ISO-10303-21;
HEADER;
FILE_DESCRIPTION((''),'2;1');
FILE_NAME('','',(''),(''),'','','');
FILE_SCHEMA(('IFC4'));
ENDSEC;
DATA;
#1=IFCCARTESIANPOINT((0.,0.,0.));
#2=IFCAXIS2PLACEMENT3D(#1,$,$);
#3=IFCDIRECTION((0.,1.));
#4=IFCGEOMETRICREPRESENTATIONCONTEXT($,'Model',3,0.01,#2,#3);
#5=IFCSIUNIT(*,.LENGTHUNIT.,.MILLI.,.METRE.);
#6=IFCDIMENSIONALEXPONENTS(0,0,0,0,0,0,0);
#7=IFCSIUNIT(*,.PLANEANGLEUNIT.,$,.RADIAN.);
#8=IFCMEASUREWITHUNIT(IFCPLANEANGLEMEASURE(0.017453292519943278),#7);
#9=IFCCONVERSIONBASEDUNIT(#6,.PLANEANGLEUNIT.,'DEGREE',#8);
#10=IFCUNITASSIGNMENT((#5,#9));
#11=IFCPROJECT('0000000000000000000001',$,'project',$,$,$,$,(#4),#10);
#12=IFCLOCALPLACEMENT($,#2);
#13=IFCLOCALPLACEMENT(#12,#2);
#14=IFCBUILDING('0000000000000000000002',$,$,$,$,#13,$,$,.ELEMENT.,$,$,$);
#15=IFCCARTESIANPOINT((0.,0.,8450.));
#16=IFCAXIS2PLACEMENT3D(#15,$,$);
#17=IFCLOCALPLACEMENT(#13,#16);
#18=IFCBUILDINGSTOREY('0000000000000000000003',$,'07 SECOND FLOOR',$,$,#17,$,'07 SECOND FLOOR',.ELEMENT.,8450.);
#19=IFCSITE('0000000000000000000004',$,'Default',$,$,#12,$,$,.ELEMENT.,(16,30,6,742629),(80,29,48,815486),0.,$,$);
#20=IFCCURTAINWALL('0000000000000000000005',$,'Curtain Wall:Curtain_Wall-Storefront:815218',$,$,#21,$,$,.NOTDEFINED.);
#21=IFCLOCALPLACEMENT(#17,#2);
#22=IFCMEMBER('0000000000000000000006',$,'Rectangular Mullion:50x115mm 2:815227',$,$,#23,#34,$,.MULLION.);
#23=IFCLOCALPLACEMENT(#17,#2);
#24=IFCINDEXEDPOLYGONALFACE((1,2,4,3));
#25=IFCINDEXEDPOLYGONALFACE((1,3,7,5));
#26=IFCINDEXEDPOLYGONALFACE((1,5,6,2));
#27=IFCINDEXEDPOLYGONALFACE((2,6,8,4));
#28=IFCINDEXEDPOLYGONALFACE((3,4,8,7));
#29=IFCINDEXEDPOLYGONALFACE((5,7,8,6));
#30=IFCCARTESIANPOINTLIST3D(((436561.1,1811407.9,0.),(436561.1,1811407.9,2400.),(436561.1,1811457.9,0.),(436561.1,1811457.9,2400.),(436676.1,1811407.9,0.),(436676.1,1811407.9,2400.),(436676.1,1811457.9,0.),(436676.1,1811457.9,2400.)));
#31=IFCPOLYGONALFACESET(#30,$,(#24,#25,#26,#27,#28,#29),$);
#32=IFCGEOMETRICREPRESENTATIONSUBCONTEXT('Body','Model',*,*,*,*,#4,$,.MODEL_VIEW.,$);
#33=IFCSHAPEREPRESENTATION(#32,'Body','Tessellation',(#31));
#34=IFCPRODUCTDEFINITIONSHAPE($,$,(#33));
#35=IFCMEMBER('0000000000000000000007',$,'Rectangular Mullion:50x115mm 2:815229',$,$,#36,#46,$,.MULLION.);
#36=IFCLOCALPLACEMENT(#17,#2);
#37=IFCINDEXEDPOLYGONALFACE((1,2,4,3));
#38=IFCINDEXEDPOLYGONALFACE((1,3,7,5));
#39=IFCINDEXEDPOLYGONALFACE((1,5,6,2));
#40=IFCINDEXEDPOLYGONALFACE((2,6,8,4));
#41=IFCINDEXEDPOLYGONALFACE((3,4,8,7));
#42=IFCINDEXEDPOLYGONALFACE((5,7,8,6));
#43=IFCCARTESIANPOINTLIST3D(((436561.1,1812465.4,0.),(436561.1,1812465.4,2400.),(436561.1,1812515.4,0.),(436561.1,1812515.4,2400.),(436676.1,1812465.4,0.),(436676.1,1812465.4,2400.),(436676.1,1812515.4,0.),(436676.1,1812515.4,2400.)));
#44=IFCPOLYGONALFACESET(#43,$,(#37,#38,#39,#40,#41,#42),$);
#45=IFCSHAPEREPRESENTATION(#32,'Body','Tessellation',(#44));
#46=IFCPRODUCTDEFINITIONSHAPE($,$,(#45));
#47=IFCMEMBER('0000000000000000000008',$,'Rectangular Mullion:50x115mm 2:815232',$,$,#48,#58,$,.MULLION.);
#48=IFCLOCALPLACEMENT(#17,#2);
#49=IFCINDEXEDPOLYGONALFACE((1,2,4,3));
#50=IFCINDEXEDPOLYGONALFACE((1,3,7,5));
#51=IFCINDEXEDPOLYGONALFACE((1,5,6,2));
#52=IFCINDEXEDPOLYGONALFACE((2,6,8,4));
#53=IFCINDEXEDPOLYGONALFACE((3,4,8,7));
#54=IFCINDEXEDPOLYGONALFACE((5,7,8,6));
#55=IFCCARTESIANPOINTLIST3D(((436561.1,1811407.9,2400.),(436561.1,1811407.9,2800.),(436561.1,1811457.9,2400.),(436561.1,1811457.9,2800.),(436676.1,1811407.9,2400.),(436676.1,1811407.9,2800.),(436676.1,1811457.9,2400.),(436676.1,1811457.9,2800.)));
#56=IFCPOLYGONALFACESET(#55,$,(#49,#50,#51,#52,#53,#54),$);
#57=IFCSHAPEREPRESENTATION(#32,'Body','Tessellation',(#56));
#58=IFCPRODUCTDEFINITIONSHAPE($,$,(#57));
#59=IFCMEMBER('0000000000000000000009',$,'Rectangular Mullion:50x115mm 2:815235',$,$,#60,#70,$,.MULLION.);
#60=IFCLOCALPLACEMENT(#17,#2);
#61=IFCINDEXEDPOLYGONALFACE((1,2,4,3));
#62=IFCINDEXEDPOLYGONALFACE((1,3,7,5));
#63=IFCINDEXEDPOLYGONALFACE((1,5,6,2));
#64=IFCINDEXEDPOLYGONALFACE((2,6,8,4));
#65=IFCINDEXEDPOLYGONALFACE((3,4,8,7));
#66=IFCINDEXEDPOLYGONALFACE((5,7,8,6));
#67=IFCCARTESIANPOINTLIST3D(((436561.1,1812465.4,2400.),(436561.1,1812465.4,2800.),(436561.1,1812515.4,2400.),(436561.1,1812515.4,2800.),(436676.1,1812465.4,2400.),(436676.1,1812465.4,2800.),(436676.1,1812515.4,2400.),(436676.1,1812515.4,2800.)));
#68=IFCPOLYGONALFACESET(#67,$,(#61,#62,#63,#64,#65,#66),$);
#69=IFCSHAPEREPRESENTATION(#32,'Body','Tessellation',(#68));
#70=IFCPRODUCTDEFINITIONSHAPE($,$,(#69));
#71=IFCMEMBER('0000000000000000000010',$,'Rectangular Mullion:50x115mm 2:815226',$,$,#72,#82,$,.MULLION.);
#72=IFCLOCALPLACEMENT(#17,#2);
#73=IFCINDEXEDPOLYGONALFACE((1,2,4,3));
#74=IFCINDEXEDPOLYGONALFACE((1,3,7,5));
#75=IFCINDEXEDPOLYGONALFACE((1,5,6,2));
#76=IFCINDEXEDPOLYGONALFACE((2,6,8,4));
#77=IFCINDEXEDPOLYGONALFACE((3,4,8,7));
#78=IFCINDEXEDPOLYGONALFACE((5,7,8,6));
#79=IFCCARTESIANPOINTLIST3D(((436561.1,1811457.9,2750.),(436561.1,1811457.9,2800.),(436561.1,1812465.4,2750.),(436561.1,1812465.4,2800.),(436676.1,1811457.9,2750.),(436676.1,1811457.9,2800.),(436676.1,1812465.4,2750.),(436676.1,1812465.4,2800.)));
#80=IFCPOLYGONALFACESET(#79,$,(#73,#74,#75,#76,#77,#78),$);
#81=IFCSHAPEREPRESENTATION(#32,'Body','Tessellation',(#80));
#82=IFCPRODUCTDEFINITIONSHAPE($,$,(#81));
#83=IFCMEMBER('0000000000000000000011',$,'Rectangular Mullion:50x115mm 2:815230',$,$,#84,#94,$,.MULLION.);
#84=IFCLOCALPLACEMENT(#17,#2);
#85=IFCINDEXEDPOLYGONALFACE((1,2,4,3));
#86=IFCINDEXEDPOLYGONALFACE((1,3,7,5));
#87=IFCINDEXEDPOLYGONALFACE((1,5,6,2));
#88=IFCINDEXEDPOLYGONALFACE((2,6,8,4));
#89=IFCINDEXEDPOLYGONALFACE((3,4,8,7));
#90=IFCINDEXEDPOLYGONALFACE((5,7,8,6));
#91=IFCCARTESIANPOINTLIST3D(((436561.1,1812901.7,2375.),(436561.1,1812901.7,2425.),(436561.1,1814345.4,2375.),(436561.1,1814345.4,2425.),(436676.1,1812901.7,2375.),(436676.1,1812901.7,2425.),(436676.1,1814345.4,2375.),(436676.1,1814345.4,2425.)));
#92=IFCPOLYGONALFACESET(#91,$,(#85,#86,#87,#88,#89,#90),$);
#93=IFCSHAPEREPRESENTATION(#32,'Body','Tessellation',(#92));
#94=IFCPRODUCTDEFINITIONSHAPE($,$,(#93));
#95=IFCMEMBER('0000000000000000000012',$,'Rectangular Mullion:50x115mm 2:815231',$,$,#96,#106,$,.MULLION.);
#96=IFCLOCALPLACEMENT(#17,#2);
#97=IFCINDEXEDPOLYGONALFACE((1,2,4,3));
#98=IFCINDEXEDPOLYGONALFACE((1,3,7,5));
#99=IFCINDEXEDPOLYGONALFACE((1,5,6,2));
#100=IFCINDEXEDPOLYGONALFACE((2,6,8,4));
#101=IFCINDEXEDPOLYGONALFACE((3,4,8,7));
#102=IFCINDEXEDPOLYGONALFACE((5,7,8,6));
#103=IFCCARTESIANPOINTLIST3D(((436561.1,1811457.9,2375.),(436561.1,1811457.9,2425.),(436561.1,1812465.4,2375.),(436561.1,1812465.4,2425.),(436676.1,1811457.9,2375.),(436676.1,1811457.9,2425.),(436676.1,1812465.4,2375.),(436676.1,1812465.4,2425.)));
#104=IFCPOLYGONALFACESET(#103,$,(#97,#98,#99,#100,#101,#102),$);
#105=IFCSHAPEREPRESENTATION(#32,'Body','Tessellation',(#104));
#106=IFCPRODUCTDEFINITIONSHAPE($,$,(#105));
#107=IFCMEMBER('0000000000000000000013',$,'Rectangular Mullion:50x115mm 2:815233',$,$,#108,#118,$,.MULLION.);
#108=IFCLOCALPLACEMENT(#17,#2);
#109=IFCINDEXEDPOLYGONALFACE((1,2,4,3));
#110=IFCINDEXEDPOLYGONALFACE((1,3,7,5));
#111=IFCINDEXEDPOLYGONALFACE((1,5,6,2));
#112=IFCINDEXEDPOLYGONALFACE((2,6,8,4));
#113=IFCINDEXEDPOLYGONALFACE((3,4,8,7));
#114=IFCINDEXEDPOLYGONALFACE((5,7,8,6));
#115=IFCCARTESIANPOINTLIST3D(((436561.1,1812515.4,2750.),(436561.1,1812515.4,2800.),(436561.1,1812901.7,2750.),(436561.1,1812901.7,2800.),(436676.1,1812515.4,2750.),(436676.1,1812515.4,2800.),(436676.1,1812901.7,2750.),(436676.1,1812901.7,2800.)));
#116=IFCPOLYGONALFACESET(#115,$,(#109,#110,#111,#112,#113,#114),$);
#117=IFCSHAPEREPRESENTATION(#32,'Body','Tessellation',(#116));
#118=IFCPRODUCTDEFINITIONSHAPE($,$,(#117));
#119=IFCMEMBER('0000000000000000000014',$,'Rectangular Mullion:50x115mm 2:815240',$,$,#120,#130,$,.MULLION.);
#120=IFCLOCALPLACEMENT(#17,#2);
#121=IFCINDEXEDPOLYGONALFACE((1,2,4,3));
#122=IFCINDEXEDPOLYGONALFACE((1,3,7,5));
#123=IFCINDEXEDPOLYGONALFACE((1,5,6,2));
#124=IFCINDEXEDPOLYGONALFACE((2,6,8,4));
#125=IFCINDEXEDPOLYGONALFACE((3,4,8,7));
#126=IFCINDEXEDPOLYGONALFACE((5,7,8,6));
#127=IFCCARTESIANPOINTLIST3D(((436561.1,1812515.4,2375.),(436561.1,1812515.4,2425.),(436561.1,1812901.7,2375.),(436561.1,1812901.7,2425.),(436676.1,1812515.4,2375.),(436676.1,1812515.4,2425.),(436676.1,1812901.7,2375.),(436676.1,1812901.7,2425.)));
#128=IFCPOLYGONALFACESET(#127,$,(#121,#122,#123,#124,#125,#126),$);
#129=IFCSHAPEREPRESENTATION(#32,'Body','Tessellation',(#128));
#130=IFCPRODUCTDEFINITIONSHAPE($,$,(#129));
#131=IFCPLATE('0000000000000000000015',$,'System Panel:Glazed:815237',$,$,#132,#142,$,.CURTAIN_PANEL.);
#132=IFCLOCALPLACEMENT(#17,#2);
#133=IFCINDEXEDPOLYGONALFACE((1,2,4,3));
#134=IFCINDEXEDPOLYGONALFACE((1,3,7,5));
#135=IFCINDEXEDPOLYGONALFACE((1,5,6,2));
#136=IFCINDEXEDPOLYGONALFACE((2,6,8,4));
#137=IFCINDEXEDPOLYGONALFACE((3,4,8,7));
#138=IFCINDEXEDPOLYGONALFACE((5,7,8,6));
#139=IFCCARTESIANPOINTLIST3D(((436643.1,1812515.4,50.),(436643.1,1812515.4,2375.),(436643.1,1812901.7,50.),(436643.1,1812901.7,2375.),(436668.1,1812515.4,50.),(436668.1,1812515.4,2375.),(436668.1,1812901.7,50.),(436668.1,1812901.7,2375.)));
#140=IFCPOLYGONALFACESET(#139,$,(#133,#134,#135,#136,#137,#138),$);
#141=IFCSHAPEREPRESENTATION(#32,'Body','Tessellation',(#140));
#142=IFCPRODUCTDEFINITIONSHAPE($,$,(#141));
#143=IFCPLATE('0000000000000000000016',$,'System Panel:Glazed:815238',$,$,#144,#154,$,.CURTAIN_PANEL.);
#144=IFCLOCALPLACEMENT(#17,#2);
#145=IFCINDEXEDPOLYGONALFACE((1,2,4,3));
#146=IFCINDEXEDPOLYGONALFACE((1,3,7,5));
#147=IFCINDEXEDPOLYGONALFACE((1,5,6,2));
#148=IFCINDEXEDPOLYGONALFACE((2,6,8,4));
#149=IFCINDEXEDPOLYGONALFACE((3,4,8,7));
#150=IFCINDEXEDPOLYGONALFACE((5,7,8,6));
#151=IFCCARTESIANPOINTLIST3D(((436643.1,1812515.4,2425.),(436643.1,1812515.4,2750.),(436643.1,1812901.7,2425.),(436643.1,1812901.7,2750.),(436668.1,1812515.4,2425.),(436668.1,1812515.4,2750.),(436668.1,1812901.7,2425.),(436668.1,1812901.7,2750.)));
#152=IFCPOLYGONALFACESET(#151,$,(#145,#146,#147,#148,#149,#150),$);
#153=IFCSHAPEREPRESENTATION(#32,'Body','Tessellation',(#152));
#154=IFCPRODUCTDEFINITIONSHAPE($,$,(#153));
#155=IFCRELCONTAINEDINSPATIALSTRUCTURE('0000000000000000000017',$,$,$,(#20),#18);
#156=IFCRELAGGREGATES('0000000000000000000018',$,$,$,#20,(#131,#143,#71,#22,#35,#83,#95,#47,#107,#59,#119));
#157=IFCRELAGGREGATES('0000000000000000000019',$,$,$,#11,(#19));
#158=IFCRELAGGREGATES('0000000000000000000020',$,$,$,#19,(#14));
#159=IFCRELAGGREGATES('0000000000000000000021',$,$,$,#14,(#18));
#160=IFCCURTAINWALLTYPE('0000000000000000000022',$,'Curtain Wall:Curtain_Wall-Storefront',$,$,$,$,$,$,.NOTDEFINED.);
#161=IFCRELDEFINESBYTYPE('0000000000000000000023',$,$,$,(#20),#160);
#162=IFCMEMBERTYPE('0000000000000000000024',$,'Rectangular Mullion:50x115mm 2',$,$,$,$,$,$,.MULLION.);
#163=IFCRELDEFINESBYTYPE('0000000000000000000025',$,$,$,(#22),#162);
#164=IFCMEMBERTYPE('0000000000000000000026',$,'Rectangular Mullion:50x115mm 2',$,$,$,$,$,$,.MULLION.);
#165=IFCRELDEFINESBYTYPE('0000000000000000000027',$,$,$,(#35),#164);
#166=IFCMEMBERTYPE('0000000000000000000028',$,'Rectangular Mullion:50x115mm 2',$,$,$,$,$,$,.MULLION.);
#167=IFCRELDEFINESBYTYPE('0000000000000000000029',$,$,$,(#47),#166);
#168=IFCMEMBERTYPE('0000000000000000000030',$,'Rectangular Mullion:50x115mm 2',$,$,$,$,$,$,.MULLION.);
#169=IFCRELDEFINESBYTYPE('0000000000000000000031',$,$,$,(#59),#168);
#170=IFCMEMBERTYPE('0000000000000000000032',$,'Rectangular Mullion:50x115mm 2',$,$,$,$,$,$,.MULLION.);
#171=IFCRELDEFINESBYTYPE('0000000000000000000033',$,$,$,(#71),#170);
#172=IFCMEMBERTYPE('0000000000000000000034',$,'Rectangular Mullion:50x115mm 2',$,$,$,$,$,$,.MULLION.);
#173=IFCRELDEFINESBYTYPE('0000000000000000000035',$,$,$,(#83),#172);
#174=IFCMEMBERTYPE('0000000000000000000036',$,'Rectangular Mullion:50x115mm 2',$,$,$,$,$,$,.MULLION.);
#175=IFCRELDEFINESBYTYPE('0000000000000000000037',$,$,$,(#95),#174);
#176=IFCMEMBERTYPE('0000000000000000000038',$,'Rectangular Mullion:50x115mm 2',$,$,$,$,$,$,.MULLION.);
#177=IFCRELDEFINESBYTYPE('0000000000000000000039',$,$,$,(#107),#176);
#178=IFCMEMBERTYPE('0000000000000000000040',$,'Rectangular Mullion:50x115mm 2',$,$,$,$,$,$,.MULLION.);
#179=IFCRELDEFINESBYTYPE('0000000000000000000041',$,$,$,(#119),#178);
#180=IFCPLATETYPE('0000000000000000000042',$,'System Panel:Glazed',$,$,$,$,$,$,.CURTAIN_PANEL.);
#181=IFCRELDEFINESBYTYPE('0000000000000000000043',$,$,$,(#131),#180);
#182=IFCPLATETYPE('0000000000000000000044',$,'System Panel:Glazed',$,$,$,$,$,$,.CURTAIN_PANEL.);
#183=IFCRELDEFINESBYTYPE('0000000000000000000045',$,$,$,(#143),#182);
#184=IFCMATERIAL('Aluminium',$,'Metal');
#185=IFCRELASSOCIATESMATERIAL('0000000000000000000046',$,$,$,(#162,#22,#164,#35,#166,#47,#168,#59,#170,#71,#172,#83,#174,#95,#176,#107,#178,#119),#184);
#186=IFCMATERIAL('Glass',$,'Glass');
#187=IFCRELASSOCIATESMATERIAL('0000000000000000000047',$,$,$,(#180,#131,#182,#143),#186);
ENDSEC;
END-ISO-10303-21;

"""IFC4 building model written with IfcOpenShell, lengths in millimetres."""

from ifc_helpers import new_model, entity, si_unit, converted_unit, direction, frame, origin, place, context, subcontext, project, spatial, indexed_curve, outline, extrude, source, transform, mapped, material, type_object, type_shapes, element, aggregate, save


model = new_model("IFC4")

# Units and contexts
model_context = context("Model", 3, precision=0.01, world=origin(), true_north=direction((0.0, 1.0)))
body_context = subcontext(model_context, "Body", "Model", "MODEL_VIEW")
ifc_project = project(units=[si_unit("LENGTHUNIT", "METRE", prefix="MILLI"), converted_unit("PLANEANGLEUNIT", "DEGREE", entity("IfcPlaneAngleMeasure", 0.017453292519943278), si_unit("PLANEANGLEUNIT", "RADIAN"), dimensions=[0, 0, 0, 0, 0, 0, 0])], contexts=[model_context])

# Site, building, storey
site_placement = place(None, origin())
site = spatial("IfcSite", under=ifc_project, at=site_placement, Name="Default", CompositionType="ELEMENT", RefLatitude=(16, 30, 6, 742629), RefLongitude=(80, 29, 48, 815486), RefElevation=0.0)
building_placement = place(site_placement, origin())
building = spatial("IfcBuilding", under=site, at=building_placement, CompositionType="ELEMENT")
storey_placement = place(building_placement, frame((0.0, 0.0, 8450.0)))
storey = spatial("IfcBuildingStorey", under=building, at=storey_placement, Name="07 SECOND FLOOR", LongName="07 SECOND FLOOR", CompositionType="ELEMENT", Elevation=8450.0)

# Curtain wall, members, plates
curtain_wall_type = type_object("IfcCurtainWallType", Name="Curtain Wall:Curtain_Wall-Storefront", PredefinedType="NOTDEFINED")
curtain_wall_placement = place(storey_placement, frame((0.0, 0.0, -8450.0)))
curtain_wall = element("IfcCurtainWall", 1, at=curtain_wall_placement, inside=storey, type_object=curtain_wall_type, Name="Curtain Wall:Curtain_Wall-Storefront:815218", PredefinedType="NOTDEFINED")
ifc_material_1 = material(Name="Aluminium", Category="Metal")
member_type_1 = type_object("IfcMemberType", Name="Rectangular Mullion:50x115mm 2", PredefinedType="MULLION", material=ifc_material_1)
shared_shape_1 = source(origin(), body_context, "Body", "SweptSolid", [
    extrude(outline(indexed_curve([(-25.0, -57.5), (25.0, -57.5), (25.0, 57.5), (-25.0, 57.5), (-25.0, -57.5)], self_intersect=False)), frame((-25.0, 0.0, -2400.0), z_axis=(0.0, 0.0, 1.0), x_axis=(-1.0, 0.0, 0.0)), (0.0, 0.0, 1.0), 2400.0),
])
type_shapes(member_type_1, [shared_shape_1])
member_1_placement = place(curtain_wall_placement, frame((436618.6, 1811407.9, 8450.0), z_axis=(0.0, 0.0, -1.0), x_axis=(0.0, -1.0, 0.0)))
member_1 = element("IfcMember", 2, at=member_1_placement, type_object=member_type_1, material=ifc_material_1, Name="Rectangular Mullion:50x115mm 2:815227", PredefinedType="MULLION", context=body_context, shape_type="MappedRepresentation", body=[
    mapped(shared_shape_1, transform((0.0, 0.0, 0.0), scale=1.0)),
])
member_type_2 = type_object("IfcMemberType", Name="Rectangular Mullion:50x115mm 2", PredefinedType="MULLION", material=ifc_material_1)
shared_shape_2 = source(origin(), body_context, "Body", "SweptSolid", [
    extrude(outline(indexed_curve([(-25.0, -57.5), (25.0, -57.5), (25.0, 57.5), (-25.0, 57.5), (-25.0, -57.5)], self_intersect=False)), frame((0.0, 0.0, -2400.0), z_axis=(0.0, 0.0, 1.0), x_axis=(-1.0, 0.0, 0.0)), (0.0, 0.0, 1.0), 2400.0),
])
type_shapes(member_type_2, [shared_shape_2])
member_2_placement = place(curtain_wall_placement, frame((436618.6, 1812490.4, 8450.0), z_axis=(0.0, 0.0, -1.0), x_axis=(0.0, -1.0, 0.0)))
member_2 = element("IfcMember", 3, at=member_2_placement, type_object=member_type_2, material=ifc_material_1, Name="Rectangular Mullion:50x115mm 2:815229", PredefinedType="MULLION", context=body_context, shape_type="MappedRepresentation", body=[
    mapped(shared_shape_2, transform((0.0, 0.0, 0.0), scale=1.0)),
])
member_type_3 = type_object("IfcMemberType", Name="Rectangular Mullion:50x115mm 2", PredefinedType="MULLION", material=ifc_material_1)
shared_shape_3 = source(origin(), body_context, "Body", "SweptSolid", [
    extrude(outline(indexed_curve([(-25.0, -57.5), (25.0, -57.5), (25.0, 57.5), (-25.0, 57.5), (-25.0, -57.5)], self_intersect=False)), frame((-25.0, 0.0, -400.0), z_axis=(0.0, 0.0, 1.0), x_axis=(-1.0, 0.0, 0.0)), (0.0, 0.0, 1.0), 400.0),
])
type_shapes(member_type_3, [shared_shape_3])
member_3_placement = place(curtain_wall_placement, frame((436618.6, 1811407.9, 10850.0), z_axis=(0.0, 0.0, -1.0), x_axis=(0.0, -1.0, 0.0)))
member_3 = element("IfcMember", 4, at=member_3_placement, type_object=member_type_3, material=ifc_material_1, Name="Rectangular Mullion:50x115mm 2:815232", PredefinedType="MULLION", context=body_context, shape_type="MappedRepresentation", body=[
    mapped(shared_shape_3, transform((0.0, 0.0, 0.0), scale=1.0)),
])
member_type_4 = type_object("IfcMemberType", Name="Rectangular Mullion:50x115mm 2", PredefinedType="MULLION", material=ifc_material_1)
shared_shape_4 = source(origin(), body_context, "Body", "SweptSolid", [
    extrude(outline(indexed_curve([(-25.0, -57.5), (25.0, -57.5), (25.0, 57.5), (-25.0, 57.5), (-25.0, -57.5)], self_intersect=False)), frame((0.0, 0.0, -400.0), z_axis=(0.0, 0.0, 1.0), x_axis=(-1.0, 0.0, 0.0)), (0.0, 0.0, 1.0), 400.0),
])
type_shapes(member_type_4, [shared_shape_4])
member_4_placement = place(curtain_wall_placement, frame((436618.6, 1812490.4, 10850.0), z_axis=(0.0, 0.0, -1.0), x_axis=(0.0, -1.0, 0.0)))
member_4 = element("IfcMember", 5, at=member_4_placement, type_object=member_type_4, material=ifc_material_1, Name="Rectangular Mullion:50x115mm 2:815235", PredefinedType="MULLION", context=body_context, shape_type="MappedRepresentation", body=[
    mapped(shared_shape_4, transform((0.0, 0.0, 0.0), scale=1.0)),
])
member_type_5 = type_object("IfcMemberType", Name="Rectangular Mullion:50x115mm 2", PredefinedType="MULLION", material=ifc_material_1)
shared_shape_5 = source(origin(), body_context, "Body", "SweptSolid", [
    extrude(outline(indexed_curve([(-25.0, -57.5), (25.0, -57.5), (25.0, 57.5), (-25.0, 57.5), (-25.0, -57.5)], self_intersect=False)), frame((-25.0, 0.0, -1007.5), z_axis=(0.0, 0.0, 1.0), x_axis=(-1.0, 0.0, 0.0)), (0.0, 0.0, 1.0), 1007.5),
])
type_shapes(member_type_5, [shared_shape_5])
member_5_placement = place(curtain_wall_placement, frame((436618.6, 1811457.9, 11250.0), z_axis=(0.0, -1.0, 0.0), x_axis=(0.0, 0.0, 1.0)))
member_5 = element("IfcMember", 6, at=member_5_placement, type_object=member_type_5, material=ifc_material_1, Name="Rectangular Mullion:50x115mm 2:815226", PredefinedType="MULLION", context=body_context, shape_type="MappedRepresentation", body=[
    mapped(shared_shape_5, transform((0.0, 0.0, 0.0), scale=1.0)),
])
member_type_6 = type_object("IfcMemberType", Name="Rectangular Mullion:50x115mm 2", PredefinedType="MULLION", material=ifc_material_1)
shared_shape_6 = source(origin(), body_context, "Body", "SweptSolid", [
    extrude(outline(indexed_curve([(-25.0, -57.5), (25.0, -57.5), (25.0, 57.5), (-25.0, 57.5), (-25.0, -57.5)], self_intersect=False)), frame((0.0, 0.0, -1443.8), z_axis=(0.0, 0.0, 1.0), x_axis=(-1.0, 0.0, 0.0)), (0.0, 0.0, 1.0), 1443.8),
])
type_shapes(member_type_6, [shared_shape_6])
member_6_placement = place(curtain_wall_placement, frame((436618.6, 1812901.7, 10850.0), z_axis=(0.0, -1.0, 0.0), x_axis=(0.0, 0.0, 1.0)))
member_6 = element("IfcMember", 7, at=member_6_placement, type_object=member_type_6, material=ifc_material_1, Name="Rectangular Mullion:50x115mm 2:815230", PredefinedType="MULLION", context=body_context, shape_type="MappedRepresentation", body=[
    mapped(shared_shape_6, transform((0.0, 0.0, 0.0), scale=1.0)),
])
member_type_7 = type_object("IfcMemberType", Name="Rectangular Mullion:50x115mm 2", PredefinedType="MULLION", material=ifc_material_1)
shared_shape_7 = source(origin(), body_context, "Body", "SweptSolid", [
    extrude(outline(indexed_curve([(-25.0, -57.5), (25.0, -57.5), (25.0, 57.5), (-25.0, 57.5), (-25.0, -57.5)], self_intersect=False)), frame((0.0, 0.0, -1007.5), z_axis=(0.0, 0.0, 1.0), x_axis=(-1.0, 0.0, 0.0)), (0.0, 0.0, 1.0), 1007.5),
])
type_shapes(member_type_7, [shared_shape_7])
member_7_placement = place(curtain_wall_placement, frame((436618.6, 1811457.9, 10850.0), z_axis=(0.0, -1.0, 0.0), x_axis=(0.0, 0.0, 1.0)))
member_7 = element("IfcMember", 8, at=member_7_placement, type_object=member_type_7, material=ifc_material_1, Name="Rectangular Mullion:50x115mm 2:815231", PredefinedType="MULLION", context=body_context, shape_type="MappedRepresentation", body=[
    mapped(shared_shape_7, transform((0.0, 0.0, 0.0), scale=1.0)),
])
member_type_8 = type_object("IfcMemberType", Name="Rectangular Mullion:50x115mm 2", PredefinedType="MULLION", material=ifc_material_1)
shared_shape_8 = source(origin(), body_context, "Body", "SweptSolid", [
    extrude(outline(indexed_curve([(-25.0, -57.5), (25.0, -57.5), (25.0, 57.5), (-25.0, 57.5), (-25.0, -57.5)], self_intersect=False)), frame((-25.0, 0.0, -386.2), z_axis=(0.0, 0.0, 1.0), x_axis=(-1.0, 0.0, 0.0)), (0.0, 0.0, 1.0), 386.2),
])
type_shapes(member_type_8, [shared_shape_8])
member_8_placement = place(curtain_wall_placement, frame((436618.6, 1812515.4, 11250.0), z_axis=(0.0, -1.0, 0.0), x_axis=(0.0, 0.0, 1.0)))
member_8 = element("IfcMember", 9, at=member_8_placement, type_object=member_type_8, material=ifc_material_1, Name="Rectangular Mullion:50x115mm 2:815233", PredefinedType="MULLION", context=body_context, shape_type="MappedRepresentation", body=[
    mapped(shared_shape_8, transform((0.0, 0.0, 0.0), scale=1.0)),
])
member_type_9 = type_object("IfcMemberType", Name="Rectangular Mullion:50x115mm 2", PredefinedType="MULLION", material=ifc_material_1)
shared_shape_9 = source(origin(), body_context, "Body", "SweptSolid", [
    extrude(outline(indexed_curve([(-25.0, -57.5), (25.0, -57.5), (25.0, 57.5), (-25.0, 57.5), (-25.0, -57.5)], self_intersect=False)), frame((0.0, 0.0, -386.2), z_axis=(0.0, 0.0, 1.0), x_axis=(-1.0, 0.0, 0.0)), (0.0, 0.0, 1.0), 386.2),
])
type_shapes(member_type_9, [shared_shape_9])
member_9_placement = place(curtain_wall_placement, frame((436618.6, 1812515.4, 10850.0), z_axis=(0.0, -1.0, 0.0), x_axis=(0.0, 0.0, 1.0)))
member_9 = element("IfcMember", 10, at=member_9_placement, type_object=member_type_9, material=ifc_material_1, Name="Rectangular Mullion:50x115mm 2:815240", PredefinedType="MULLION", context=body_context, shape_type="MappedRepresentation", body=[
    mapped(shared_shape_9, transform((0.0, 0.0, 0.0), scale=1.0)),
])
ifc_material_2 = material(Name="Glass", Category="Glass")
plate_type_1 = type_object("IfcPlateType", Name="System Panel:Glazed", PredefinedType="CURTAIN_PANEL", material=ifc_material_2)
shared_shape_10 = source(origin(), body_context, "Body", "SweptSolid", [
    extrude(outline(indexed_curve([(-12.5, -193.1), (12.5, -193.1), (12.5, 193.1), (-12.5, 193.1), (-12.5, -193.1)], self_intersect=False)), frame((0.0, 37.0, 0.0), z_axis=(0.0, 0.0, 1.0), x_axis=(0.0, 1.0, 0.0)), (0.0, 0.0, 1.0), 2325.0),
])
type_shapes(plate_type_1, [shared_shape_10])
plate_1_placement = place(curtain_wall_placement, frame((436618.6, 1812708.5, 8500.0), z_axis=(0.0, 0.0, 1.0), x_axis=(0.0, -1.0, 0.0)))
plate_1 = element("IfcPlate", 11, at=plate_1_placement, type_object=plate_type_1, material=ifc_material_2, Name="System Panel:Glazed:815237", PredefinedType="CURTAIN_PANEL", context=body_context, shape_type="MappedRepresentation", body=[
    mapped(shared_shape_10, transform((0.0, 0.0, 0.0), scale=1.0)),
])
plate_type_2 = type_object("IfcPlateType", Name="System Panel:Glazed", PredefinedType="CURTAIN_PANEL", material=ifc_material_2)
shared_shape_11 = source(origin(), body_context, "Body", "SweptSolid", [
    extrude(outline(indexed_curve([(-12.5, -193.1), (12.5, -193.1), (12.5, 193.1), (-12.5, 193.1), (-12.5, -193.1)], self_intersect=False)), frame((0.0, 37.0, 0.0), z_axis=(0.0, 0.0, 1.0), x_axis=(0.0, 1.0, 0.0)), (0.0, 0.0, 1.0), 325.0),
])
type_shapes(plate_type_2, [shared_shape_11])
plate_2_placement = place(curtain_wall_placement, frame((436618.6, 1812708.5, 10875.0), z_axis=(0.0, 0.0, 1.0), x_axis=(0.0, -1.0, 0.0)))
plate_2 = element("IfcPlate", 12, at=plate_2_placement, type_object=plate_type_2, material=ifc_material_2, Name="System Panel:Glazed:815238", PredefinedType="CURTAIN_PANEL", context=body_context, shape_type="MappedRepresentation", body=[
    mapped(shared_shape_11, transform((0.0, 0.0, 0.0), scale=1.0)),
])

aggregate(curtain_wall, [plate_1, plate_2, member_5, member_1, member_2, member_6, member_7, member_3, member_8, member_4, member_9])

save(model, "model.ifc")
